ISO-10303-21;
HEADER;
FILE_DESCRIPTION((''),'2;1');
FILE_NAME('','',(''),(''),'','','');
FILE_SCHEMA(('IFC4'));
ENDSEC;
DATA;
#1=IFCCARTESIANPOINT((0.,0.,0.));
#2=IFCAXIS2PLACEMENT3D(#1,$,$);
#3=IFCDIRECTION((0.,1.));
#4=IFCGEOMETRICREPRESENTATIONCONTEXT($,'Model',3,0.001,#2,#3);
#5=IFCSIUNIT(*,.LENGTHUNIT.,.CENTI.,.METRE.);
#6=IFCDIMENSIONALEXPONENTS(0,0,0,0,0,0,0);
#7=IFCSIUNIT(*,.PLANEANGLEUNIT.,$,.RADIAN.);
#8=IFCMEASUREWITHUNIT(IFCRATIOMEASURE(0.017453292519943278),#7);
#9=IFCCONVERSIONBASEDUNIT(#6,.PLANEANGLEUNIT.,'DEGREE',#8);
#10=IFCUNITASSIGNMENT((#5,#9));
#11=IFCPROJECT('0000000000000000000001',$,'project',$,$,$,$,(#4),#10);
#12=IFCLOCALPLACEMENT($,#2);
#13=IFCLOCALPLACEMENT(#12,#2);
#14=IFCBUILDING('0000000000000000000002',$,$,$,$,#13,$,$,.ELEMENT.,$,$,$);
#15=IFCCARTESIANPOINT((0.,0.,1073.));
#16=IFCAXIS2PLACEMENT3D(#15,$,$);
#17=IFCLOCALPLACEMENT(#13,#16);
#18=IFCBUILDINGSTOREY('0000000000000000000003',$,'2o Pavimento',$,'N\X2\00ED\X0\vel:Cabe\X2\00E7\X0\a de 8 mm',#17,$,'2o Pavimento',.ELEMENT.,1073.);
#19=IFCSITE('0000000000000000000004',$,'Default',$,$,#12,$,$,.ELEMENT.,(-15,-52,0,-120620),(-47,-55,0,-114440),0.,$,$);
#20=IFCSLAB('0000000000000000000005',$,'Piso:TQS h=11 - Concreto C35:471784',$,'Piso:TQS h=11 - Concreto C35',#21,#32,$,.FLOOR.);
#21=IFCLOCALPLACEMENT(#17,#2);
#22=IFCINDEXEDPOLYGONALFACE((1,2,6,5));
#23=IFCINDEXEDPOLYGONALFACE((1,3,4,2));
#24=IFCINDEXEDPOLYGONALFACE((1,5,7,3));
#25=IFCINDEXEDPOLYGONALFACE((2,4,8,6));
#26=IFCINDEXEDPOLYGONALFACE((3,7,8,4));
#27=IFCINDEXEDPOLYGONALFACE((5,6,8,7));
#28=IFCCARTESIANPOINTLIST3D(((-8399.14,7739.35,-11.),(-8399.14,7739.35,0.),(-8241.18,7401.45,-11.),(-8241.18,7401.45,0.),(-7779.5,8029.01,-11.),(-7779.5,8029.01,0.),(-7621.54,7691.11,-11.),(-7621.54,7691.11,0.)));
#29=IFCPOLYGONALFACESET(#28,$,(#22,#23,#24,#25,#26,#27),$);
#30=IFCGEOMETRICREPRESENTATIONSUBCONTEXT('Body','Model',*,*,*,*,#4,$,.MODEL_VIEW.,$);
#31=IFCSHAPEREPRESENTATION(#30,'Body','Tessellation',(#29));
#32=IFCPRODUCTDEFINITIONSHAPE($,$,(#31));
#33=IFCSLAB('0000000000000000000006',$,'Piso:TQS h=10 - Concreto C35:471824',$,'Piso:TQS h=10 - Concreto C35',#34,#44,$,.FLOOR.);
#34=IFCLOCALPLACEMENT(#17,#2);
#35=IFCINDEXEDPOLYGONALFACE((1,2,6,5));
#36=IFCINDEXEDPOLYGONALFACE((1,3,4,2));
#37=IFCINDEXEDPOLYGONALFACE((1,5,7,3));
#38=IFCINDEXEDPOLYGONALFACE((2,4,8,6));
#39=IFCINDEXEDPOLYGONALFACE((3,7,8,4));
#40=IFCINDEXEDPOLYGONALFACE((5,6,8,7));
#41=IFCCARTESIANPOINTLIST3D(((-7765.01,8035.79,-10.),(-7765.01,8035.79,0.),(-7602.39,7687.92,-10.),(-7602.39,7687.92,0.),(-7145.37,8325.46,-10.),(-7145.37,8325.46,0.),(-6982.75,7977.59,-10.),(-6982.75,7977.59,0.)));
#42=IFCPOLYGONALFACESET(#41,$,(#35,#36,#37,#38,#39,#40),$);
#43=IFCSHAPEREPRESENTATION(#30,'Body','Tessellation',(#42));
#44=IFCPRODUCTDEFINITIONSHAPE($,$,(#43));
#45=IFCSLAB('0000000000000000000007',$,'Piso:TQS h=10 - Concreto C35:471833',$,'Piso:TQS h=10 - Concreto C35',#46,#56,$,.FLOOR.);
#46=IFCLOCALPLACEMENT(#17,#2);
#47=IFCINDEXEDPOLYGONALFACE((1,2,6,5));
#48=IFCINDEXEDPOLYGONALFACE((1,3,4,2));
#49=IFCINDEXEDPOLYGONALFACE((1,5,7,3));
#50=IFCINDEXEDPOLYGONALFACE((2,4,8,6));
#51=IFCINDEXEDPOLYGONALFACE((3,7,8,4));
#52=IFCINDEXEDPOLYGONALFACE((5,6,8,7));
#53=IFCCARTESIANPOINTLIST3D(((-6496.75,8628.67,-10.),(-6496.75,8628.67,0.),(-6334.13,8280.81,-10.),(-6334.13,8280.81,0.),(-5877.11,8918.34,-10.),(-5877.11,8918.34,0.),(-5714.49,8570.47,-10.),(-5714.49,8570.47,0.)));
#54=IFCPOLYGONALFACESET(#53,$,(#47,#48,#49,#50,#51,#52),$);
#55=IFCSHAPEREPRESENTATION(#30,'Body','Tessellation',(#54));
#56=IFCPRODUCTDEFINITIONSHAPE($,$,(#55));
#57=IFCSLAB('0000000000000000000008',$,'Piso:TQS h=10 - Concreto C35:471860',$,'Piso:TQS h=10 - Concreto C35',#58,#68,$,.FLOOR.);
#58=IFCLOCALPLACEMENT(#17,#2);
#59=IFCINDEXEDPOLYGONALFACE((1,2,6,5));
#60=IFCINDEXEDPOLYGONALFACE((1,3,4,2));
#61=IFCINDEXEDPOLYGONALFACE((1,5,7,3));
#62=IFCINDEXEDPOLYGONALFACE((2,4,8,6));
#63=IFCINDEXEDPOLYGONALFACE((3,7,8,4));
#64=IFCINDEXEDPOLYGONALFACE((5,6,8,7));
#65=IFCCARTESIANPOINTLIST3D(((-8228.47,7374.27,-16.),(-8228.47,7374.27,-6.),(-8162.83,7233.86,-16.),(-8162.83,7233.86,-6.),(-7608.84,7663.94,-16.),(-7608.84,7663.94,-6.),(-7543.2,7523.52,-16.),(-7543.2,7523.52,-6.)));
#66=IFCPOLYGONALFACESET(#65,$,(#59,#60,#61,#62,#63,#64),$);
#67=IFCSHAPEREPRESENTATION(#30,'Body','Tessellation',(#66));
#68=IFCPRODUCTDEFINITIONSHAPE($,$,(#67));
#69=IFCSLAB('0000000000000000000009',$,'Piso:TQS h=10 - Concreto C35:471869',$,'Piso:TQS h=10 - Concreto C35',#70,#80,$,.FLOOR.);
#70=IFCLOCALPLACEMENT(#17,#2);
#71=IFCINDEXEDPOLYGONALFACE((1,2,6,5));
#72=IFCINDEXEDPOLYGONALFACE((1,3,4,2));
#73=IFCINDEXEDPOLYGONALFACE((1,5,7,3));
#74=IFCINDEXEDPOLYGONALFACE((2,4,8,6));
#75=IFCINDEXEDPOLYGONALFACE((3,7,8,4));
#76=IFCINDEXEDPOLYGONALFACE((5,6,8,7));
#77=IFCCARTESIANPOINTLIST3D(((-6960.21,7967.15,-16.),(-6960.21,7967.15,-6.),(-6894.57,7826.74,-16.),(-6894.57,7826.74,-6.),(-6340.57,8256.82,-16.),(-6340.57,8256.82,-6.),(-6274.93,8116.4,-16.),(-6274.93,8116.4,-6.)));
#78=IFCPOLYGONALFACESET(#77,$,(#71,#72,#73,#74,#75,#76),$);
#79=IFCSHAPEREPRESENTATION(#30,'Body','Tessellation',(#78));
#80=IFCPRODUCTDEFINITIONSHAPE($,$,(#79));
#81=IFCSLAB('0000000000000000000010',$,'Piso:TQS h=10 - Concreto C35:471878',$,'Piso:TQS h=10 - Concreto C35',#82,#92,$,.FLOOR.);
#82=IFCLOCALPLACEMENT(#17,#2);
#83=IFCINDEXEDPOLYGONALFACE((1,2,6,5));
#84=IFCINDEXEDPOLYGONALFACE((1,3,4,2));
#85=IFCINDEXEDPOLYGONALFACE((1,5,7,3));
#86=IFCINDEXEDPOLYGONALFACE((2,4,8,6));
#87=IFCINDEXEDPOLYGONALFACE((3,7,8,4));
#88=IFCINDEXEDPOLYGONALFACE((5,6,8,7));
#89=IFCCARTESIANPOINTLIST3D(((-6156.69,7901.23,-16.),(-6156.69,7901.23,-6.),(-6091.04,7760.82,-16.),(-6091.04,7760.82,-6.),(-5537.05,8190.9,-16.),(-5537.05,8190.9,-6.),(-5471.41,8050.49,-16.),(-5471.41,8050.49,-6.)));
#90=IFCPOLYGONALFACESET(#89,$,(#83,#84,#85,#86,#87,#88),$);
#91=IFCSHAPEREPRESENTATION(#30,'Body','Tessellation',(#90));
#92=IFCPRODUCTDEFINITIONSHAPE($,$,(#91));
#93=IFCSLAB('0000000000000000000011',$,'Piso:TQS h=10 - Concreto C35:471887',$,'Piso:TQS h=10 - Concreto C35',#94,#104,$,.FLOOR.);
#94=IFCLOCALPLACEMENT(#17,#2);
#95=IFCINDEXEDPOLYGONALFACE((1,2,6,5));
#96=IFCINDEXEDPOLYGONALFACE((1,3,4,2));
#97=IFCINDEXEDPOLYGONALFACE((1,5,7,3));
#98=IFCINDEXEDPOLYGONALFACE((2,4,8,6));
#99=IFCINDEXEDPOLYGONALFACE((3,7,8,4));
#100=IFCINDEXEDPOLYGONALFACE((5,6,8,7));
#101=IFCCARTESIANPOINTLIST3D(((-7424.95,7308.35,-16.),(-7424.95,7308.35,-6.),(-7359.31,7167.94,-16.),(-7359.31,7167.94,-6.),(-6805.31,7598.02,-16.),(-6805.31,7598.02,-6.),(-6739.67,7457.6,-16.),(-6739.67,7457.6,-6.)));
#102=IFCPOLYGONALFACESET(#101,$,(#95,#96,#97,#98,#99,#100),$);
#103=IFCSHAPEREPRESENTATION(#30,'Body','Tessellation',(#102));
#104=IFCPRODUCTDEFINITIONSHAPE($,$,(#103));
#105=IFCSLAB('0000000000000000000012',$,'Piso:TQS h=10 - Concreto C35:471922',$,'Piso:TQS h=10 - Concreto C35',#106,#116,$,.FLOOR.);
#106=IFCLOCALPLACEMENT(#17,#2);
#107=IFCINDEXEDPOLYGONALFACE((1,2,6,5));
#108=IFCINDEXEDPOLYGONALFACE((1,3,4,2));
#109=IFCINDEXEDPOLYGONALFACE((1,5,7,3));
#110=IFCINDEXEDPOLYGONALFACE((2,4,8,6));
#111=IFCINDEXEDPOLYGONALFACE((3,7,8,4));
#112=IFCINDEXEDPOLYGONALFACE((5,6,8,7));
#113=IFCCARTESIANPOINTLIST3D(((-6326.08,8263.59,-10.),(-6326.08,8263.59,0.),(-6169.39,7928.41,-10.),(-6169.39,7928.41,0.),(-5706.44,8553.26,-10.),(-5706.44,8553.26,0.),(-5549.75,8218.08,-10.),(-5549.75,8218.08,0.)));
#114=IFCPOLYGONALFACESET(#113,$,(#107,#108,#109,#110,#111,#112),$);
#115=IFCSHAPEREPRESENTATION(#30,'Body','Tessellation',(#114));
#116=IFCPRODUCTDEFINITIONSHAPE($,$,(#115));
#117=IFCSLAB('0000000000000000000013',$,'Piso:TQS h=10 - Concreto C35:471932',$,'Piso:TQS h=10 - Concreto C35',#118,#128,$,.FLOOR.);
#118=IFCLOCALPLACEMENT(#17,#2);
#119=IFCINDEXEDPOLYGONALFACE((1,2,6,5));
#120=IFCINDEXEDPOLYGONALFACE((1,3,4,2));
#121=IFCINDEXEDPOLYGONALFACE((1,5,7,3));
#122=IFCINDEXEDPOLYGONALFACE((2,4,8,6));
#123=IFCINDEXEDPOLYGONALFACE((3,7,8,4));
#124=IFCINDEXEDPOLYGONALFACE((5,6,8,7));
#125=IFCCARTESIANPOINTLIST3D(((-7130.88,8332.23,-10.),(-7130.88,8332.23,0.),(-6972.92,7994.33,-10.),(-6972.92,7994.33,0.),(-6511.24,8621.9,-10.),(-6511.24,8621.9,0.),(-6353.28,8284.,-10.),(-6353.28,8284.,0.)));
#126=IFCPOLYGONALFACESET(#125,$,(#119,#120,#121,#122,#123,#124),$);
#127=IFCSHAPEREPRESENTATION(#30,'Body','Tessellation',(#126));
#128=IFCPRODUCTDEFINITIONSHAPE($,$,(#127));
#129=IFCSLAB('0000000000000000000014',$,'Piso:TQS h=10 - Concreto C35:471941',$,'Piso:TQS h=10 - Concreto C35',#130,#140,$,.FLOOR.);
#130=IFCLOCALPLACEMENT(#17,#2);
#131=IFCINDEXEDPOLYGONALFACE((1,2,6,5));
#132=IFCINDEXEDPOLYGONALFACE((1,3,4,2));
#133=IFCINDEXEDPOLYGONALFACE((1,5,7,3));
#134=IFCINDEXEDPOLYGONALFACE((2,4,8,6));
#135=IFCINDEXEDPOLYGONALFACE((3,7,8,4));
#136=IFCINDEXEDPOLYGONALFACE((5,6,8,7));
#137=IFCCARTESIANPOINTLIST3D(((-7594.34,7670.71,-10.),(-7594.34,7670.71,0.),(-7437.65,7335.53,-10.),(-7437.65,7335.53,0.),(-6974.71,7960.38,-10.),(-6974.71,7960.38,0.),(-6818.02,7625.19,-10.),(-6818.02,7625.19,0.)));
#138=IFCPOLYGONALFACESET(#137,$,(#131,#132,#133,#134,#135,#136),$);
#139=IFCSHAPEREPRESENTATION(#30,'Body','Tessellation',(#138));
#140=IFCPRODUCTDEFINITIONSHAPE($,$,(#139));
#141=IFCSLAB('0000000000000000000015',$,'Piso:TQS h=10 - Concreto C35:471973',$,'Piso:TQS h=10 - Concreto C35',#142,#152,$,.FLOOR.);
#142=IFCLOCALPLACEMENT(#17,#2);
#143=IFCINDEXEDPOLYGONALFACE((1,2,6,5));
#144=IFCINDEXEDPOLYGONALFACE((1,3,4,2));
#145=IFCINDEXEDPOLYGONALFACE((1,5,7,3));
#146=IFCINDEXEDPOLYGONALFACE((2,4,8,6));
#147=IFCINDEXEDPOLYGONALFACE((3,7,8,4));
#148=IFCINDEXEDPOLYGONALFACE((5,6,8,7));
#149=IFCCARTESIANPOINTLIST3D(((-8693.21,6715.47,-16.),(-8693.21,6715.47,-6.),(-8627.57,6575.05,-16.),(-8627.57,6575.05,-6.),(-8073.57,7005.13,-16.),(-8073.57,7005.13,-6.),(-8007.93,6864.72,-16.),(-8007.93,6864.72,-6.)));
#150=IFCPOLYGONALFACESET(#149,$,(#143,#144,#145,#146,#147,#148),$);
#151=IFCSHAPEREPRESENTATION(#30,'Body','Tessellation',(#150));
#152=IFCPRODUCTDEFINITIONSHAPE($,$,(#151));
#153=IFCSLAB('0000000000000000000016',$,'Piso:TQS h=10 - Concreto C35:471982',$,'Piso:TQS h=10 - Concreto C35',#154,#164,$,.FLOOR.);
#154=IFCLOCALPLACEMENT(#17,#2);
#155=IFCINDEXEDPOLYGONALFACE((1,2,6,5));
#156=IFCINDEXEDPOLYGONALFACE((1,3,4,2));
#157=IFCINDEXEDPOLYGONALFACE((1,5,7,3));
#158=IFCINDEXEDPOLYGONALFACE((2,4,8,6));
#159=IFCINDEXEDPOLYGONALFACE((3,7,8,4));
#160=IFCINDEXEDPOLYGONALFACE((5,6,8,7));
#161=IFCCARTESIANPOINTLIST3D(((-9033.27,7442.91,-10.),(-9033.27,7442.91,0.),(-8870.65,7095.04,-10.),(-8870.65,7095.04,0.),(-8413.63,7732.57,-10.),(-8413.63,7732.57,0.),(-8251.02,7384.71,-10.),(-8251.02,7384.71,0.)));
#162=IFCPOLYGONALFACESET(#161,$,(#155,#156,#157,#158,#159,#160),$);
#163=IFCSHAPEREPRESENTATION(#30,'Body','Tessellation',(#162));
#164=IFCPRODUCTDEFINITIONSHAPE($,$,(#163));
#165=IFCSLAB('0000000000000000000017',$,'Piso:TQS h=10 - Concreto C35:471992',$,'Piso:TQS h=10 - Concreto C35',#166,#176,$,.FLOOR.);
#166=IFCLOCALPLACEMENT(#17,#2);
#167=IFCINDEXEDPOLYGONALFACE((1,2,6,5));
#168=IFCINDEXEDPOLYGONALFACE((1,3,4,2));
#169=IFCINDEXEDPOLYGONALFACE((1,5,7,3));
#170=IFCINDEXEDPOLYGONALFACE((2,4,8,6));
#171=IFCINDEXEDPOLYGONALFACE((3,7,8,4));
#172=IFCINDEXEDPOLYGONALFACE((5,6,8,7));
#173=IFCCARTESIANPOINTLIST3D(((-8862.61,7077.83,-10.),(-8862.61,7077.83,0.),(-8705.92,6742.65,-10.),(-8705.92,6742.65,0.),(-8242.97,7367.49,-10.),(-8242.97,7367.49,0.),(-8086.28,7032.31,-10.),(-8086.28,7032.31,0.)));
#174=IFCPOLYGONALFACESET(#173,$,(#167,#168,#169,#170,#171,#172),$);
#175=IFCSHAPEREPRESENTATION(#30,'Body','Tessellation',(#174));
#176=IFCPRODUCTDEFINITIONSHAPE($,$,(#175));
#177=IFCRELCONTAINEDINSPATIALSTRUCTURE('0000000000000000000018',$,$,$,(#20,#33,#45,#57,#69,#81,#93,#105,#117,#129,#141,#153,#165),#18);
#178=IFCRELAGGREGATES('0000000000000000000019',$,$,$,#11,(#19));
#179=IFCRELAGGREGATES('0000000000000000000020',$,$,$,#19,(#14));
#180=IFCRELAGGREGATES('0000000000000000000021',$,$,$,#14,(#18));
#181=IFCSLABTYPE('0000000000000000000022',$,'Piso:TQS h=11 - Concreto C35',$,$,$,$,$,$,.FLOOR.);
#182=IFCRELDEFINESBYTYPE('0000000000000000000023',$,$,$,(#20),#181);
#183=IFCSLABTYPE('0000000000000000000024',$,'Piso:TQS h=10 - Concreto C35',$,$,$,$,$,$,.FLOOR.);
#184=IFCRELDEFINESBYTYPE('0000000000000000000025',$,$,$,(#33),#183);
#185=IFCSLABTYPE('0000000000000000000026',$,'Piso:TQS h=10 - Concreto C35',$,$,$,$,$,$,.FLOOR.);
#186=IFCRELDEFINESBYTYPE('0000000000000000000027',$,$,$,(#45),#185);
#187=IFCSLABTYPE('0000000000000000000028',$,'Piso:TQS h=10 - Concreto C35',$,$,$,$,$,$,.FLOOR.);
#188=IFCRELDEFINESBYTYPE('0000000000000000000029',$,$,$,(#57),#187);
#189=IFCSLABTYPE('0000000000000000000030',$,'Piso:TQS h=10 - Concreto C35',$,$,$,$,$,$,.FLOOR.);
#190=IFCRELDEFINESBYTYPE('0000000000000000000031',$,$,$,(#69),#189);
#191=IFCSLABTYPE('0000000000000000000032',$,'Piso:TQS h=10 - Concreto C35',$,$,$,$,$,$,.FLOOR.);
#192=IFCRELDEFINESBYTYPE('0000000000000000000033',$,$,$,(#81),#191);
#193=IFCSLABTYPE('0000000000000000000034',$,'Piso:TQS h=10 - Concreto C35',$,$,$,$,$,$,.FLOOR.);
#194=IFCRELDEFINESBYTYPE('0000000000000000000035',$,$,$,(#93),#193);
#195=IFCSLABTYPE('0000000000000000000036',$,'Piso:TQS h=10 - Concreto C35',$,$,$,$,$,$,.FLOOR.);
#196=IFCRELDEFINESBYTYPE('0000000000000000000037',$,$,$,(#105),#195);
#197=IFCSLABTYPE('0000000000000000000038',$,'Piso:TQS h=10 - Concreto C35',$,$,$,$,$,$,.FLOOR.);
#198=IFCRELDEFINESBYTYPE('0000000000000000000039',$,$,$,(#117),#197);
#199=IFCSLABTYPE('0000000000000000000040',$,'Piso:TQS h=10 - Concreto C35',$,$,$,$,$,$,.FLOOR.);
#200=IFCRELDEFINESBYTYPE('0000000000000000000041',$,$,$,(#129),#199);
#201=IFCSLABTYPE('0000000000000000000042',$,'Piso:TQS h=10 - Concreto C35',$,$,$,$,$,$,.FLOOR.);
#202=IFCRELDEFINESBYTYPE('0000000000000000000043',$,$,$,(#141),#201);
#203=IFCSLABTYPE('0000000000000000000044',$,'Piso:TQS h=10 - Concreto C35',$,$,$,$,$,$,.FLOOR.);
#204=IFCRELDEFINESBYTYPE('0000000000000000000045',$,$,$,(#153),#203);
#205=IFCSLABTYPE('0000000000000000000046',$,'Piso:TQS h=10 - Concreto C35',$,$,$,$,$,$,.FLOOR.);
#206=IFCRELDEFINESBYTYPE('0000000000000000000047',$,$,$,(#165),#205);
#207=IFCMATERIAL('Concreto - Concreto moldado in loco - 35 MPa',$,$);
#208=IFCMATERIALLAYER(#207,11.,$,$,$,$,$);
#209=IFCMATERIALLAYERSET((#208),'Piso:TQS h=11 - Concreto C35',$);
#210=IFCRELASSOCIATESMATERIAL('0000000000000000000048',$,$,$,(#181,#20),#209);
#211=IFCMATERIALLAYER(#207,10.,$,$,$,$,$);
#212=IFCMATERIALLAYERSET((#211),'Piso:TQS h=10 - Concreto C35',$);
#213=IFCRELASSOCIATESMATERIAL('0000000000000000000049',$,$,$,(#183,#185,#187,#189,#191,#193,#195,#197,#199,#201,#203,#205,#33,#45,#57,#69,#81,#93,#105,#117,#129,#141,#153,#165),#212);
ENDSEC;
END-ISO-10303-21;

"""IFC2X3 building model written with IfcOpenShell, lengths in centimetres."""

from ifc_helpers import new_model, entity, si_unit, converted_unit, direction, frame, frame_2d, origin, origin_2d_with_axis, place, context, subcontext, project, spatial, rectangle, extrude, material, layer, layer_set, layer_usage, type_object, element, save


model = new_model("IFC2X3")

# Units and contexts
model_context = context("Model", 3, precision=0.001, world=origin(), true_north=direction((0.0, 1.0)))
body_context = subcontext(model_context, "Body", "Model", "MODEL_VIEW")
ifc_project = project(units=[si_unit("LENGTHUNIT", "METRE", prefix="CENTI"), converted_unit("PLANEANGLEUNIT", "DEGREE", entity("IfcRatioMeasure", 0.017453292519943278), si_unit("PLANEANGLEUNIT", "RADIAN"), dimensions=[0, 0, 0, 0, 0, 0, 0])], contexts=[model_context])

# Site, building, storey
site_placement = place(None, origin())
site = spatial("IfcSite", under=ifc_project, at=site_placement, Name="Default", CompositionType="ELEMENT", RefLatitude=(-15, -52, 0, -120620), RefLongitude=(-47, -55, 0, -114440), RefElevation=0.0)
building_placement = place(site_placement, origin())
building = spatial("IfcBuilding", under=site, at=building_placement, CompositionType="ELEMENT")
storey_placement = place(building_placement, frame((0.0, 0.0, 1073.0)))
storey = spatial("IfcBuildingStorey", under=building, at=storey_placement, Name="2o Pavimento", ObjectType="Nível:Cabeça de 8 mm", LongName="2o Pavimento", CompositionType="ELEMENT", Elevation=1073.0)

# Slabs
ifc_material = material(Name="Concreto - Concreto moldado in loco - 35 MPa")
ifc_layer_1 = layer(ifc_material, 11.0)
ifc_layer_set_1 = layer_set([ifc_layer_1], Name="Piso:TQS h=11 - Concreto C35")
ifc_layer_usage_1 = layer_usage(ifc_layer_set_1, "AXIS3", "POSITIVE", 0.0)
slab_type_1 = type_object("IfcSlabType", Name="Piso:TQS h=11 - Concreto C35", PredefinedType="FLOOR", material=ifc_layer_set_1)
slab_1_placement = place(storey_placement, origin())
element("IfcSlab", 1, at=slab_1_placement, inside=storey, type_object=slab_type_1, material=ifc_layer_usage_1, Name="Piso:TQS h=11 - Concreto C35:471784", ObjectType="Piso:TQS h=11 - Concreto C35", PredefinedType="FLOOR", context=body_context, shape_type="SweptSolid", body=[
    extrude(rectangle(XDim=373.0, YDim=684.0, at=frame_2d((0.0, 0.0), x_axis=(1.0, 0.0))), frame((-8010.34, 7715.23, 0.0), z_axis=(0.0, 0.0, -1.0), x_axis=(0.423488, -0.905902, 0.0)), (0.0, 0.0, 1.0), 11.0),
])
ifc_layer_2 = layer(ifc_material, 10.0)
ifc_layer_set_2 = layer_set([ifc_layer_2], Name="Piso:TQS h=10 - Concreto C35")
ifc_layer_usage_2 = layer_usage(ifc_layer_set_2, "AXIS3", "POSITIVE", 0.0)
slab_type_2 = type_object("IfcSlabType", Name="Piso:TQS h=10 - Concreto C35", PredefinedType="FLOOR", material=ifc_layer_set_2)
slab_2_placement = place(storey_placement, origin())
element("IfcSlab", 2, at=slab_2_placement, inside=storey, type_object=slab_type_2, material=ifc_layer_usage_2, Name="Piso:TQS h=10 - Concreto C35:471824", ObjectType="Piso:TQS h=10 - Concreto C35", PredefinedType="FLOOR", context=body_context, shape_type="SweptSolid", body=[
    extrude(rectangle(XDim=384.0, YDim=684.0, at=frame_2d((0.0, 0.0), x_axis=(1.0, 0.0))), frame((-7373.88, 8006.69, 0.0), z_axis=(0.0, 0.0, -1.0), x_axis=(0.423488, -0.905902, 0.0)), (0.0, 0.0, 1.0), 10.0),
])
ifc_layer_usage_3 = layer_usage(ifc_layer_set_2, "AXIS3", "POSITIVE", 0.0)
slab_type_3 = type_object("IfcSlabType", Name="Piso:TQS h=10 - Concreto C35", PredefinedType="FLOOR", material=ifc_layer_set_2)
slab_3_placement = place(storey_placement, origin())
element("IfcSlab", 3, at=slab_3_placement, inside=storey, type_object=slab_type_3, material=ifc_layer_usage_3, Name="Piso:TQS h=10 - Concreto C35:471833", ObjectType="Piso:TQS h=10 - Concreto C35", PredefinedType="FLOOR", context=body_context, shape_type="SweptSolid", body=[
    extrude(rectangle(XDim=684.0, YDim=384.0, at=frame_2d((0.0, 0.0), x_axis=(1.0, 0.0))), frame((-6105.62, 8599.57, 0.0), z_axis=(0.0, 0.0, -1.0), x_axis=(0.905902, 0.423488, 0.0)), (0.0, 0.0, 1.0), 10.0),
])
ifc_layer_usage_4 = layer_usage(ifc_layer_set_2, "AXIS3", "POSITIVE", 0.0)
slab_type_4 = type_object("IfcSlabType", Name="Piso:TQS h=10 - Concreto C35", PredefinedType="FLOOR", material=ifc_layer_set_2)
slab_4_placement = place(storey_placement, origin())
element("IfcSlab", 4, at=slab_4_placement, inside=storey, type_object=slab_type_4, material=ifc_layer_usage_4, Name="Piso:TQS h=10 - Concreto C35:471860", ObjectType="Piso:TQS h=10 - Concreto C35", PredefinedType="FLOOR", context=body_context, shape_type="SweptSolid", body=[
    extrude(rectangle(XDim=155.0, YDim=684.0, at=frame_2d((0.0, 0.0), x_axis=(1.0, 0.0))), frame((-7885.84, 7448.9, -6.0), z_axis=(0.0, 0.0, -1.0), x_axis=(0.423488, -0.905902, 0.0)), (0.0, 0.0, 1.0), 10.0),
])
ifc_layer_usage_5 = layer_usage(ifc_layer_set_2, "AXIS3", "POSITIVE", 0.0)
slab_type_5 = type_object("IfcSlabType", Name="Piso:TQS h=10 - Concreto C35", PredefinedType="FLOOR", material=ifc_layer_set_2)
slab_5_placement = place(storey_placement, origin())
element("IfcSlab", 5, at=slab_5_placement, inside=storey, type_object=slab_type_5, material=ifc_layer_usage_5, Name="Piso:TQS h=10 - Concreto C35:471869", ObjectType="Piso:TQS h=10 - Concreto C35", PredefinedType="FLOOR", context=body_context, shape_type="SweptSolid", body=[
    extrude(rectangle(XDim=155.0, YDim=684.0, at=frame_2d((0.0, 0.0), x_axis=(1.0, 0.0))), frame((-6617.57, 8041.78, -6.0), z_axis=(0.0, 0.0, -1.0), x_axis=(0.423488, -0.905902, 0.0)), (0.0, 0.0, 1.0), 10.0),
])
ifc_layer_usage_6 = layer_usage(ifc_layer_set_2, "AXIS3", "POSITIVE", 0.0)
slab_type_6 = type_object("IfcSlabType", Name="Piso:TQS h=10 - Concreto C35", PredefinedType="FLOOR", material=ifc_layer_set_2)
slab_6_placement = place(storey_placement, origin())
element("IfcSlab", 6, at=slab_6_placement, inside=storey, type_object=slab_type_6, material=ifc_layer_usage_6, Name="Piso:TQS h=10 - Concreto C35:471878", ObjectType="Piso:TQS h=10 - Concreto C35", PredefinedType="FLOOR", context=body_context, shape_type="SweptSolid", body=[
    extrude(rectangle(XDim=684.0, YDim=155.0, at=origin_2d_with_axis()), frame((-5814.05, 7975.86, -6.0), z_axis=(0.0, 0.0, -1.0), x_axis=(0.905902, 0.423488, 0.0)), (0.0, 0.0, 1.0), 10.0),
])
ifc_layer_usage_7 = layer_usage(ifc_layer_set_2, "AXIS3", "POSITIVE", 0.0)
slab_type_7 = type_object("IfcSlabType", Name="Piso:TQS h=10 - Concreto C35", PredefinedType="FLOOR", material=ifc_layer_set_2)
slab_7_placement = place(storey_placement, origin())
element("IfcSlab", 7, at=slab_7_placement, inside=storey, type_object=slab_type_7, material=ifc_layer_usage_7, Name="Piso:TQS h=10 - Concreto C35:471887", ObjectType="Piso:TQS h=10 - Concreto C35", PredefinedType="FLOOR", context=body_context, shape_type="SweptSolid", body=[
    extrude(rectangle(XDim=684.0, YDim=155.0, at=frame_2d((0.0, 0.0), x_axis=(1.0, 0.0))), frame((-7082.31, 7382.98, -6.0), z_axis=(0.0, 0.0, -1.0), x_axis=(0.905902, 0.423488, 0.0)), (0.0, 0.0, 1.0), 10.0),
])
ifc_layer_usage_8 = layer_usage(ifc_layer_set_2, "AXIS3", "POSITIVE", 0.0)
slab_type_8 = type_object("IfcSlabType", Name="Piso:TQS h=10 - Concreto C35", PredefinedType="FLOOR", material=ifc_layer_set_2)
slab_8_placement = place(storey_placement, origin())
element("IfcSlab", 8, at=slab_8_placement, inside=storey, type_object=slab_type_8, material=ifc_layer_usage_8, Name="Piso:TQS h=10 - Concreto C35:471922", ObjectType="Piso:TQS h=10 - Concreto C35", PredefinedType="FLOOR", context=body_context, shape_type="SweptSolid", body=[
    extrude(rectangle(XDim=370.0, YDim=684.0, at=frame_2d((0.0, 0.0), x_axis=(1.0, 0.0))), frame((-5937.92, 8240.84, 0.0), z_axis=(0.0, 0.0, -1.0), x_axis=(0.423488, -0.905902, 0.0)), (0.0, 0.0, 1.0), 10.0),
])
ifc_layer_usage_9 = layer_usage(ifc_layer_set_2, "AXIS3", "POSITIVE", 0.0)
slab_type_9 = type_object("IfcSlabType", Name="Piso:TQS h=10 - Concreto C35", PredefinedType="FLOOR", material=ifc_layer_set_2)
slab_9_placement = place(storey_placement, origin())
element("IfcSlab", 9, at=slab_9_placement, inside=storey, type_object=slab_type_9, material=ifc_layer_usage_9, Name="Piso:TQS h=10 - Concreto C35:471932", ObjectType="Piso:TQS h=10 - Concreto C35", PredefinedType="FLOOR", context=body_context, shape_type="SweptSolid", body=[
    extrude(rectangle(XDim=684.0, YDim=373.0, at=origin_2d_with_axis()), frame((-6742.08, 8308.11, 0.0), z_axis=(0.0, 0.0, -1.0), x_axis=(0.905902, 0.423488, 0.0)), (0.0, 0.0, 1.0), 10.0),
])
ifc_layer_usage_10 = layer_usage(ifc_layer_set_2, "AXIS3", "POSITIVE", 0.0)
slab_type_10 = type_object("IfcSlabType", Name="Piso:TQS h=10 - Concreto C35", PredefinedType="FLOOR", material=ifc_layer_set_2)
slab_10_placement = place(storey_placement, origin())
element("IfcSlab", 10, at=slab_10_placement, inside=storey, type_object=slab_type_10, material=ifc_layer_usage_10, Name="Piso:TQS h=10 - Concreto C35:471941", ObjectType="Piso:TQS h=10 - Concreto C35", PredefinedType="FLOOR", context=body_context, shape_type="SweptSolid", body=[
    extrude(rectangle(XDim=370.0, YDim=684.0, at=frame_2d((0.0, 0.0), x_axis=(1.0, 0.0))), frame((-7206.18, 7647.95, 0.0), z_axis=(0.0, 0.0, -1.0), x_axis=(0.423488, -0.905902, 0.0)), (0.0, 0.0, 1.0), 10.0),
])
ifc_layer_usage_11 = layer_usage(ifc_layer_set_2, "AXIS3", "POSITIVE", 0.0)
slab_type_11 = type_object("IfcSlabType", Name="Piso:TQS h=10 - Concreto C35", PredefinedType="FLOOR", material=ifc_layer_set_2)
slab_11_placement = place(storey_placement, origin())
element("IfcSlab", 11, at=slab_11_placement, inside=storey, type_object=slab_type_11, material=ifc_layer_usage_11, Name="Piso:TQS h=10 - Concreto C35:471973", ObjectType="Piso:TQS h=10 - Concreto C35", PredefinedType="FLOOR", context=body_context, shape_type="SweptSolid", body=[
    extrude(rectangle(XDim=155.0, YDim=684.0, at=frame_2d((0.0, 0.0), x_axis=(1.0, 0.0))), frame((-8350.57, 6790.09, -6.0), z_axis=(0.0, 0.0, -1.0), x_axis=(0.423488, -0.905902, 0.0)), (0.0, 0.0, 1.0), 10.0),
])
ifc_layer_usage_12 = layer_usage(ifc_layer_set_2, "AXIS3", "POSITIVE", 0.0)
slab_type_12 = type_object("IfcSlabType", Name="Piso:TQS h=10 - Concreto C35", PredefinedType="FLOOR", material=ifc_layer_set_2)
slab_12_placement = place(storey_placement, origin())
element("IfcSlab", 12, at=slab_12_placement, inside=storey, type_object=slab_type_12, material=ifc_layer_usage_12, Name="Piso:TQS h=10 - Concreto C35:471982", ObjectType="Piso:TQS h=10 - Concreto C35", PredefinedType="FLOOR", context=body_context, shape_type="SweptSolid", body=[
    extrude(rectangle(XDim=384.0, YDim=684.0, at=origin_2d_with_axis()), frame((-8642.14, 7413.81, 0.0), z_axis=(0.0, 0.0, -1.0), x_axis=(0.423488, -0.905902, 0.0)), (0.0, 0.0, 1.0), 10.0),
])
ifc_layer_usage_13 = layer_usage(ifc_layer_set_2, "AXIS3", "POSITIVE", 0.0)
slab_type_13 = type_object("IfcSlabType", Name="Piso:TQS h=10 - Concreto C35", PredefinedType="FLOOR", material=ifc_layer_set_2)
slab_13_placement = place(storey_placement, origin())
element("IfcSlab", 13, at=slab_13_placement, inside=storey, type_object=slab_type_13, material=ifc_layer_usage_13, Name="Piso:TQS h=10 - Concreto C35:471992", ObjectType="Piso:TQS h=10 - Concreto C35", PredefinedType="FLOOR", context=body_context, shape_type="SweptSolid", body=[
    extrude(rectangle(XDim=684.0, YDim=370.0, at=frame_2d((0.0, 0.0), x_axis=(1.0, 0.0))), frame((-8474.44, 7055.07, 0.0), z_axis=(0.0, 0.0, -1.0), x_axis=(0.905902, 0.423488, 0.0)), (0.0, 0.0, 1.0), 10.0),
])

save(model, "model.ifc")
